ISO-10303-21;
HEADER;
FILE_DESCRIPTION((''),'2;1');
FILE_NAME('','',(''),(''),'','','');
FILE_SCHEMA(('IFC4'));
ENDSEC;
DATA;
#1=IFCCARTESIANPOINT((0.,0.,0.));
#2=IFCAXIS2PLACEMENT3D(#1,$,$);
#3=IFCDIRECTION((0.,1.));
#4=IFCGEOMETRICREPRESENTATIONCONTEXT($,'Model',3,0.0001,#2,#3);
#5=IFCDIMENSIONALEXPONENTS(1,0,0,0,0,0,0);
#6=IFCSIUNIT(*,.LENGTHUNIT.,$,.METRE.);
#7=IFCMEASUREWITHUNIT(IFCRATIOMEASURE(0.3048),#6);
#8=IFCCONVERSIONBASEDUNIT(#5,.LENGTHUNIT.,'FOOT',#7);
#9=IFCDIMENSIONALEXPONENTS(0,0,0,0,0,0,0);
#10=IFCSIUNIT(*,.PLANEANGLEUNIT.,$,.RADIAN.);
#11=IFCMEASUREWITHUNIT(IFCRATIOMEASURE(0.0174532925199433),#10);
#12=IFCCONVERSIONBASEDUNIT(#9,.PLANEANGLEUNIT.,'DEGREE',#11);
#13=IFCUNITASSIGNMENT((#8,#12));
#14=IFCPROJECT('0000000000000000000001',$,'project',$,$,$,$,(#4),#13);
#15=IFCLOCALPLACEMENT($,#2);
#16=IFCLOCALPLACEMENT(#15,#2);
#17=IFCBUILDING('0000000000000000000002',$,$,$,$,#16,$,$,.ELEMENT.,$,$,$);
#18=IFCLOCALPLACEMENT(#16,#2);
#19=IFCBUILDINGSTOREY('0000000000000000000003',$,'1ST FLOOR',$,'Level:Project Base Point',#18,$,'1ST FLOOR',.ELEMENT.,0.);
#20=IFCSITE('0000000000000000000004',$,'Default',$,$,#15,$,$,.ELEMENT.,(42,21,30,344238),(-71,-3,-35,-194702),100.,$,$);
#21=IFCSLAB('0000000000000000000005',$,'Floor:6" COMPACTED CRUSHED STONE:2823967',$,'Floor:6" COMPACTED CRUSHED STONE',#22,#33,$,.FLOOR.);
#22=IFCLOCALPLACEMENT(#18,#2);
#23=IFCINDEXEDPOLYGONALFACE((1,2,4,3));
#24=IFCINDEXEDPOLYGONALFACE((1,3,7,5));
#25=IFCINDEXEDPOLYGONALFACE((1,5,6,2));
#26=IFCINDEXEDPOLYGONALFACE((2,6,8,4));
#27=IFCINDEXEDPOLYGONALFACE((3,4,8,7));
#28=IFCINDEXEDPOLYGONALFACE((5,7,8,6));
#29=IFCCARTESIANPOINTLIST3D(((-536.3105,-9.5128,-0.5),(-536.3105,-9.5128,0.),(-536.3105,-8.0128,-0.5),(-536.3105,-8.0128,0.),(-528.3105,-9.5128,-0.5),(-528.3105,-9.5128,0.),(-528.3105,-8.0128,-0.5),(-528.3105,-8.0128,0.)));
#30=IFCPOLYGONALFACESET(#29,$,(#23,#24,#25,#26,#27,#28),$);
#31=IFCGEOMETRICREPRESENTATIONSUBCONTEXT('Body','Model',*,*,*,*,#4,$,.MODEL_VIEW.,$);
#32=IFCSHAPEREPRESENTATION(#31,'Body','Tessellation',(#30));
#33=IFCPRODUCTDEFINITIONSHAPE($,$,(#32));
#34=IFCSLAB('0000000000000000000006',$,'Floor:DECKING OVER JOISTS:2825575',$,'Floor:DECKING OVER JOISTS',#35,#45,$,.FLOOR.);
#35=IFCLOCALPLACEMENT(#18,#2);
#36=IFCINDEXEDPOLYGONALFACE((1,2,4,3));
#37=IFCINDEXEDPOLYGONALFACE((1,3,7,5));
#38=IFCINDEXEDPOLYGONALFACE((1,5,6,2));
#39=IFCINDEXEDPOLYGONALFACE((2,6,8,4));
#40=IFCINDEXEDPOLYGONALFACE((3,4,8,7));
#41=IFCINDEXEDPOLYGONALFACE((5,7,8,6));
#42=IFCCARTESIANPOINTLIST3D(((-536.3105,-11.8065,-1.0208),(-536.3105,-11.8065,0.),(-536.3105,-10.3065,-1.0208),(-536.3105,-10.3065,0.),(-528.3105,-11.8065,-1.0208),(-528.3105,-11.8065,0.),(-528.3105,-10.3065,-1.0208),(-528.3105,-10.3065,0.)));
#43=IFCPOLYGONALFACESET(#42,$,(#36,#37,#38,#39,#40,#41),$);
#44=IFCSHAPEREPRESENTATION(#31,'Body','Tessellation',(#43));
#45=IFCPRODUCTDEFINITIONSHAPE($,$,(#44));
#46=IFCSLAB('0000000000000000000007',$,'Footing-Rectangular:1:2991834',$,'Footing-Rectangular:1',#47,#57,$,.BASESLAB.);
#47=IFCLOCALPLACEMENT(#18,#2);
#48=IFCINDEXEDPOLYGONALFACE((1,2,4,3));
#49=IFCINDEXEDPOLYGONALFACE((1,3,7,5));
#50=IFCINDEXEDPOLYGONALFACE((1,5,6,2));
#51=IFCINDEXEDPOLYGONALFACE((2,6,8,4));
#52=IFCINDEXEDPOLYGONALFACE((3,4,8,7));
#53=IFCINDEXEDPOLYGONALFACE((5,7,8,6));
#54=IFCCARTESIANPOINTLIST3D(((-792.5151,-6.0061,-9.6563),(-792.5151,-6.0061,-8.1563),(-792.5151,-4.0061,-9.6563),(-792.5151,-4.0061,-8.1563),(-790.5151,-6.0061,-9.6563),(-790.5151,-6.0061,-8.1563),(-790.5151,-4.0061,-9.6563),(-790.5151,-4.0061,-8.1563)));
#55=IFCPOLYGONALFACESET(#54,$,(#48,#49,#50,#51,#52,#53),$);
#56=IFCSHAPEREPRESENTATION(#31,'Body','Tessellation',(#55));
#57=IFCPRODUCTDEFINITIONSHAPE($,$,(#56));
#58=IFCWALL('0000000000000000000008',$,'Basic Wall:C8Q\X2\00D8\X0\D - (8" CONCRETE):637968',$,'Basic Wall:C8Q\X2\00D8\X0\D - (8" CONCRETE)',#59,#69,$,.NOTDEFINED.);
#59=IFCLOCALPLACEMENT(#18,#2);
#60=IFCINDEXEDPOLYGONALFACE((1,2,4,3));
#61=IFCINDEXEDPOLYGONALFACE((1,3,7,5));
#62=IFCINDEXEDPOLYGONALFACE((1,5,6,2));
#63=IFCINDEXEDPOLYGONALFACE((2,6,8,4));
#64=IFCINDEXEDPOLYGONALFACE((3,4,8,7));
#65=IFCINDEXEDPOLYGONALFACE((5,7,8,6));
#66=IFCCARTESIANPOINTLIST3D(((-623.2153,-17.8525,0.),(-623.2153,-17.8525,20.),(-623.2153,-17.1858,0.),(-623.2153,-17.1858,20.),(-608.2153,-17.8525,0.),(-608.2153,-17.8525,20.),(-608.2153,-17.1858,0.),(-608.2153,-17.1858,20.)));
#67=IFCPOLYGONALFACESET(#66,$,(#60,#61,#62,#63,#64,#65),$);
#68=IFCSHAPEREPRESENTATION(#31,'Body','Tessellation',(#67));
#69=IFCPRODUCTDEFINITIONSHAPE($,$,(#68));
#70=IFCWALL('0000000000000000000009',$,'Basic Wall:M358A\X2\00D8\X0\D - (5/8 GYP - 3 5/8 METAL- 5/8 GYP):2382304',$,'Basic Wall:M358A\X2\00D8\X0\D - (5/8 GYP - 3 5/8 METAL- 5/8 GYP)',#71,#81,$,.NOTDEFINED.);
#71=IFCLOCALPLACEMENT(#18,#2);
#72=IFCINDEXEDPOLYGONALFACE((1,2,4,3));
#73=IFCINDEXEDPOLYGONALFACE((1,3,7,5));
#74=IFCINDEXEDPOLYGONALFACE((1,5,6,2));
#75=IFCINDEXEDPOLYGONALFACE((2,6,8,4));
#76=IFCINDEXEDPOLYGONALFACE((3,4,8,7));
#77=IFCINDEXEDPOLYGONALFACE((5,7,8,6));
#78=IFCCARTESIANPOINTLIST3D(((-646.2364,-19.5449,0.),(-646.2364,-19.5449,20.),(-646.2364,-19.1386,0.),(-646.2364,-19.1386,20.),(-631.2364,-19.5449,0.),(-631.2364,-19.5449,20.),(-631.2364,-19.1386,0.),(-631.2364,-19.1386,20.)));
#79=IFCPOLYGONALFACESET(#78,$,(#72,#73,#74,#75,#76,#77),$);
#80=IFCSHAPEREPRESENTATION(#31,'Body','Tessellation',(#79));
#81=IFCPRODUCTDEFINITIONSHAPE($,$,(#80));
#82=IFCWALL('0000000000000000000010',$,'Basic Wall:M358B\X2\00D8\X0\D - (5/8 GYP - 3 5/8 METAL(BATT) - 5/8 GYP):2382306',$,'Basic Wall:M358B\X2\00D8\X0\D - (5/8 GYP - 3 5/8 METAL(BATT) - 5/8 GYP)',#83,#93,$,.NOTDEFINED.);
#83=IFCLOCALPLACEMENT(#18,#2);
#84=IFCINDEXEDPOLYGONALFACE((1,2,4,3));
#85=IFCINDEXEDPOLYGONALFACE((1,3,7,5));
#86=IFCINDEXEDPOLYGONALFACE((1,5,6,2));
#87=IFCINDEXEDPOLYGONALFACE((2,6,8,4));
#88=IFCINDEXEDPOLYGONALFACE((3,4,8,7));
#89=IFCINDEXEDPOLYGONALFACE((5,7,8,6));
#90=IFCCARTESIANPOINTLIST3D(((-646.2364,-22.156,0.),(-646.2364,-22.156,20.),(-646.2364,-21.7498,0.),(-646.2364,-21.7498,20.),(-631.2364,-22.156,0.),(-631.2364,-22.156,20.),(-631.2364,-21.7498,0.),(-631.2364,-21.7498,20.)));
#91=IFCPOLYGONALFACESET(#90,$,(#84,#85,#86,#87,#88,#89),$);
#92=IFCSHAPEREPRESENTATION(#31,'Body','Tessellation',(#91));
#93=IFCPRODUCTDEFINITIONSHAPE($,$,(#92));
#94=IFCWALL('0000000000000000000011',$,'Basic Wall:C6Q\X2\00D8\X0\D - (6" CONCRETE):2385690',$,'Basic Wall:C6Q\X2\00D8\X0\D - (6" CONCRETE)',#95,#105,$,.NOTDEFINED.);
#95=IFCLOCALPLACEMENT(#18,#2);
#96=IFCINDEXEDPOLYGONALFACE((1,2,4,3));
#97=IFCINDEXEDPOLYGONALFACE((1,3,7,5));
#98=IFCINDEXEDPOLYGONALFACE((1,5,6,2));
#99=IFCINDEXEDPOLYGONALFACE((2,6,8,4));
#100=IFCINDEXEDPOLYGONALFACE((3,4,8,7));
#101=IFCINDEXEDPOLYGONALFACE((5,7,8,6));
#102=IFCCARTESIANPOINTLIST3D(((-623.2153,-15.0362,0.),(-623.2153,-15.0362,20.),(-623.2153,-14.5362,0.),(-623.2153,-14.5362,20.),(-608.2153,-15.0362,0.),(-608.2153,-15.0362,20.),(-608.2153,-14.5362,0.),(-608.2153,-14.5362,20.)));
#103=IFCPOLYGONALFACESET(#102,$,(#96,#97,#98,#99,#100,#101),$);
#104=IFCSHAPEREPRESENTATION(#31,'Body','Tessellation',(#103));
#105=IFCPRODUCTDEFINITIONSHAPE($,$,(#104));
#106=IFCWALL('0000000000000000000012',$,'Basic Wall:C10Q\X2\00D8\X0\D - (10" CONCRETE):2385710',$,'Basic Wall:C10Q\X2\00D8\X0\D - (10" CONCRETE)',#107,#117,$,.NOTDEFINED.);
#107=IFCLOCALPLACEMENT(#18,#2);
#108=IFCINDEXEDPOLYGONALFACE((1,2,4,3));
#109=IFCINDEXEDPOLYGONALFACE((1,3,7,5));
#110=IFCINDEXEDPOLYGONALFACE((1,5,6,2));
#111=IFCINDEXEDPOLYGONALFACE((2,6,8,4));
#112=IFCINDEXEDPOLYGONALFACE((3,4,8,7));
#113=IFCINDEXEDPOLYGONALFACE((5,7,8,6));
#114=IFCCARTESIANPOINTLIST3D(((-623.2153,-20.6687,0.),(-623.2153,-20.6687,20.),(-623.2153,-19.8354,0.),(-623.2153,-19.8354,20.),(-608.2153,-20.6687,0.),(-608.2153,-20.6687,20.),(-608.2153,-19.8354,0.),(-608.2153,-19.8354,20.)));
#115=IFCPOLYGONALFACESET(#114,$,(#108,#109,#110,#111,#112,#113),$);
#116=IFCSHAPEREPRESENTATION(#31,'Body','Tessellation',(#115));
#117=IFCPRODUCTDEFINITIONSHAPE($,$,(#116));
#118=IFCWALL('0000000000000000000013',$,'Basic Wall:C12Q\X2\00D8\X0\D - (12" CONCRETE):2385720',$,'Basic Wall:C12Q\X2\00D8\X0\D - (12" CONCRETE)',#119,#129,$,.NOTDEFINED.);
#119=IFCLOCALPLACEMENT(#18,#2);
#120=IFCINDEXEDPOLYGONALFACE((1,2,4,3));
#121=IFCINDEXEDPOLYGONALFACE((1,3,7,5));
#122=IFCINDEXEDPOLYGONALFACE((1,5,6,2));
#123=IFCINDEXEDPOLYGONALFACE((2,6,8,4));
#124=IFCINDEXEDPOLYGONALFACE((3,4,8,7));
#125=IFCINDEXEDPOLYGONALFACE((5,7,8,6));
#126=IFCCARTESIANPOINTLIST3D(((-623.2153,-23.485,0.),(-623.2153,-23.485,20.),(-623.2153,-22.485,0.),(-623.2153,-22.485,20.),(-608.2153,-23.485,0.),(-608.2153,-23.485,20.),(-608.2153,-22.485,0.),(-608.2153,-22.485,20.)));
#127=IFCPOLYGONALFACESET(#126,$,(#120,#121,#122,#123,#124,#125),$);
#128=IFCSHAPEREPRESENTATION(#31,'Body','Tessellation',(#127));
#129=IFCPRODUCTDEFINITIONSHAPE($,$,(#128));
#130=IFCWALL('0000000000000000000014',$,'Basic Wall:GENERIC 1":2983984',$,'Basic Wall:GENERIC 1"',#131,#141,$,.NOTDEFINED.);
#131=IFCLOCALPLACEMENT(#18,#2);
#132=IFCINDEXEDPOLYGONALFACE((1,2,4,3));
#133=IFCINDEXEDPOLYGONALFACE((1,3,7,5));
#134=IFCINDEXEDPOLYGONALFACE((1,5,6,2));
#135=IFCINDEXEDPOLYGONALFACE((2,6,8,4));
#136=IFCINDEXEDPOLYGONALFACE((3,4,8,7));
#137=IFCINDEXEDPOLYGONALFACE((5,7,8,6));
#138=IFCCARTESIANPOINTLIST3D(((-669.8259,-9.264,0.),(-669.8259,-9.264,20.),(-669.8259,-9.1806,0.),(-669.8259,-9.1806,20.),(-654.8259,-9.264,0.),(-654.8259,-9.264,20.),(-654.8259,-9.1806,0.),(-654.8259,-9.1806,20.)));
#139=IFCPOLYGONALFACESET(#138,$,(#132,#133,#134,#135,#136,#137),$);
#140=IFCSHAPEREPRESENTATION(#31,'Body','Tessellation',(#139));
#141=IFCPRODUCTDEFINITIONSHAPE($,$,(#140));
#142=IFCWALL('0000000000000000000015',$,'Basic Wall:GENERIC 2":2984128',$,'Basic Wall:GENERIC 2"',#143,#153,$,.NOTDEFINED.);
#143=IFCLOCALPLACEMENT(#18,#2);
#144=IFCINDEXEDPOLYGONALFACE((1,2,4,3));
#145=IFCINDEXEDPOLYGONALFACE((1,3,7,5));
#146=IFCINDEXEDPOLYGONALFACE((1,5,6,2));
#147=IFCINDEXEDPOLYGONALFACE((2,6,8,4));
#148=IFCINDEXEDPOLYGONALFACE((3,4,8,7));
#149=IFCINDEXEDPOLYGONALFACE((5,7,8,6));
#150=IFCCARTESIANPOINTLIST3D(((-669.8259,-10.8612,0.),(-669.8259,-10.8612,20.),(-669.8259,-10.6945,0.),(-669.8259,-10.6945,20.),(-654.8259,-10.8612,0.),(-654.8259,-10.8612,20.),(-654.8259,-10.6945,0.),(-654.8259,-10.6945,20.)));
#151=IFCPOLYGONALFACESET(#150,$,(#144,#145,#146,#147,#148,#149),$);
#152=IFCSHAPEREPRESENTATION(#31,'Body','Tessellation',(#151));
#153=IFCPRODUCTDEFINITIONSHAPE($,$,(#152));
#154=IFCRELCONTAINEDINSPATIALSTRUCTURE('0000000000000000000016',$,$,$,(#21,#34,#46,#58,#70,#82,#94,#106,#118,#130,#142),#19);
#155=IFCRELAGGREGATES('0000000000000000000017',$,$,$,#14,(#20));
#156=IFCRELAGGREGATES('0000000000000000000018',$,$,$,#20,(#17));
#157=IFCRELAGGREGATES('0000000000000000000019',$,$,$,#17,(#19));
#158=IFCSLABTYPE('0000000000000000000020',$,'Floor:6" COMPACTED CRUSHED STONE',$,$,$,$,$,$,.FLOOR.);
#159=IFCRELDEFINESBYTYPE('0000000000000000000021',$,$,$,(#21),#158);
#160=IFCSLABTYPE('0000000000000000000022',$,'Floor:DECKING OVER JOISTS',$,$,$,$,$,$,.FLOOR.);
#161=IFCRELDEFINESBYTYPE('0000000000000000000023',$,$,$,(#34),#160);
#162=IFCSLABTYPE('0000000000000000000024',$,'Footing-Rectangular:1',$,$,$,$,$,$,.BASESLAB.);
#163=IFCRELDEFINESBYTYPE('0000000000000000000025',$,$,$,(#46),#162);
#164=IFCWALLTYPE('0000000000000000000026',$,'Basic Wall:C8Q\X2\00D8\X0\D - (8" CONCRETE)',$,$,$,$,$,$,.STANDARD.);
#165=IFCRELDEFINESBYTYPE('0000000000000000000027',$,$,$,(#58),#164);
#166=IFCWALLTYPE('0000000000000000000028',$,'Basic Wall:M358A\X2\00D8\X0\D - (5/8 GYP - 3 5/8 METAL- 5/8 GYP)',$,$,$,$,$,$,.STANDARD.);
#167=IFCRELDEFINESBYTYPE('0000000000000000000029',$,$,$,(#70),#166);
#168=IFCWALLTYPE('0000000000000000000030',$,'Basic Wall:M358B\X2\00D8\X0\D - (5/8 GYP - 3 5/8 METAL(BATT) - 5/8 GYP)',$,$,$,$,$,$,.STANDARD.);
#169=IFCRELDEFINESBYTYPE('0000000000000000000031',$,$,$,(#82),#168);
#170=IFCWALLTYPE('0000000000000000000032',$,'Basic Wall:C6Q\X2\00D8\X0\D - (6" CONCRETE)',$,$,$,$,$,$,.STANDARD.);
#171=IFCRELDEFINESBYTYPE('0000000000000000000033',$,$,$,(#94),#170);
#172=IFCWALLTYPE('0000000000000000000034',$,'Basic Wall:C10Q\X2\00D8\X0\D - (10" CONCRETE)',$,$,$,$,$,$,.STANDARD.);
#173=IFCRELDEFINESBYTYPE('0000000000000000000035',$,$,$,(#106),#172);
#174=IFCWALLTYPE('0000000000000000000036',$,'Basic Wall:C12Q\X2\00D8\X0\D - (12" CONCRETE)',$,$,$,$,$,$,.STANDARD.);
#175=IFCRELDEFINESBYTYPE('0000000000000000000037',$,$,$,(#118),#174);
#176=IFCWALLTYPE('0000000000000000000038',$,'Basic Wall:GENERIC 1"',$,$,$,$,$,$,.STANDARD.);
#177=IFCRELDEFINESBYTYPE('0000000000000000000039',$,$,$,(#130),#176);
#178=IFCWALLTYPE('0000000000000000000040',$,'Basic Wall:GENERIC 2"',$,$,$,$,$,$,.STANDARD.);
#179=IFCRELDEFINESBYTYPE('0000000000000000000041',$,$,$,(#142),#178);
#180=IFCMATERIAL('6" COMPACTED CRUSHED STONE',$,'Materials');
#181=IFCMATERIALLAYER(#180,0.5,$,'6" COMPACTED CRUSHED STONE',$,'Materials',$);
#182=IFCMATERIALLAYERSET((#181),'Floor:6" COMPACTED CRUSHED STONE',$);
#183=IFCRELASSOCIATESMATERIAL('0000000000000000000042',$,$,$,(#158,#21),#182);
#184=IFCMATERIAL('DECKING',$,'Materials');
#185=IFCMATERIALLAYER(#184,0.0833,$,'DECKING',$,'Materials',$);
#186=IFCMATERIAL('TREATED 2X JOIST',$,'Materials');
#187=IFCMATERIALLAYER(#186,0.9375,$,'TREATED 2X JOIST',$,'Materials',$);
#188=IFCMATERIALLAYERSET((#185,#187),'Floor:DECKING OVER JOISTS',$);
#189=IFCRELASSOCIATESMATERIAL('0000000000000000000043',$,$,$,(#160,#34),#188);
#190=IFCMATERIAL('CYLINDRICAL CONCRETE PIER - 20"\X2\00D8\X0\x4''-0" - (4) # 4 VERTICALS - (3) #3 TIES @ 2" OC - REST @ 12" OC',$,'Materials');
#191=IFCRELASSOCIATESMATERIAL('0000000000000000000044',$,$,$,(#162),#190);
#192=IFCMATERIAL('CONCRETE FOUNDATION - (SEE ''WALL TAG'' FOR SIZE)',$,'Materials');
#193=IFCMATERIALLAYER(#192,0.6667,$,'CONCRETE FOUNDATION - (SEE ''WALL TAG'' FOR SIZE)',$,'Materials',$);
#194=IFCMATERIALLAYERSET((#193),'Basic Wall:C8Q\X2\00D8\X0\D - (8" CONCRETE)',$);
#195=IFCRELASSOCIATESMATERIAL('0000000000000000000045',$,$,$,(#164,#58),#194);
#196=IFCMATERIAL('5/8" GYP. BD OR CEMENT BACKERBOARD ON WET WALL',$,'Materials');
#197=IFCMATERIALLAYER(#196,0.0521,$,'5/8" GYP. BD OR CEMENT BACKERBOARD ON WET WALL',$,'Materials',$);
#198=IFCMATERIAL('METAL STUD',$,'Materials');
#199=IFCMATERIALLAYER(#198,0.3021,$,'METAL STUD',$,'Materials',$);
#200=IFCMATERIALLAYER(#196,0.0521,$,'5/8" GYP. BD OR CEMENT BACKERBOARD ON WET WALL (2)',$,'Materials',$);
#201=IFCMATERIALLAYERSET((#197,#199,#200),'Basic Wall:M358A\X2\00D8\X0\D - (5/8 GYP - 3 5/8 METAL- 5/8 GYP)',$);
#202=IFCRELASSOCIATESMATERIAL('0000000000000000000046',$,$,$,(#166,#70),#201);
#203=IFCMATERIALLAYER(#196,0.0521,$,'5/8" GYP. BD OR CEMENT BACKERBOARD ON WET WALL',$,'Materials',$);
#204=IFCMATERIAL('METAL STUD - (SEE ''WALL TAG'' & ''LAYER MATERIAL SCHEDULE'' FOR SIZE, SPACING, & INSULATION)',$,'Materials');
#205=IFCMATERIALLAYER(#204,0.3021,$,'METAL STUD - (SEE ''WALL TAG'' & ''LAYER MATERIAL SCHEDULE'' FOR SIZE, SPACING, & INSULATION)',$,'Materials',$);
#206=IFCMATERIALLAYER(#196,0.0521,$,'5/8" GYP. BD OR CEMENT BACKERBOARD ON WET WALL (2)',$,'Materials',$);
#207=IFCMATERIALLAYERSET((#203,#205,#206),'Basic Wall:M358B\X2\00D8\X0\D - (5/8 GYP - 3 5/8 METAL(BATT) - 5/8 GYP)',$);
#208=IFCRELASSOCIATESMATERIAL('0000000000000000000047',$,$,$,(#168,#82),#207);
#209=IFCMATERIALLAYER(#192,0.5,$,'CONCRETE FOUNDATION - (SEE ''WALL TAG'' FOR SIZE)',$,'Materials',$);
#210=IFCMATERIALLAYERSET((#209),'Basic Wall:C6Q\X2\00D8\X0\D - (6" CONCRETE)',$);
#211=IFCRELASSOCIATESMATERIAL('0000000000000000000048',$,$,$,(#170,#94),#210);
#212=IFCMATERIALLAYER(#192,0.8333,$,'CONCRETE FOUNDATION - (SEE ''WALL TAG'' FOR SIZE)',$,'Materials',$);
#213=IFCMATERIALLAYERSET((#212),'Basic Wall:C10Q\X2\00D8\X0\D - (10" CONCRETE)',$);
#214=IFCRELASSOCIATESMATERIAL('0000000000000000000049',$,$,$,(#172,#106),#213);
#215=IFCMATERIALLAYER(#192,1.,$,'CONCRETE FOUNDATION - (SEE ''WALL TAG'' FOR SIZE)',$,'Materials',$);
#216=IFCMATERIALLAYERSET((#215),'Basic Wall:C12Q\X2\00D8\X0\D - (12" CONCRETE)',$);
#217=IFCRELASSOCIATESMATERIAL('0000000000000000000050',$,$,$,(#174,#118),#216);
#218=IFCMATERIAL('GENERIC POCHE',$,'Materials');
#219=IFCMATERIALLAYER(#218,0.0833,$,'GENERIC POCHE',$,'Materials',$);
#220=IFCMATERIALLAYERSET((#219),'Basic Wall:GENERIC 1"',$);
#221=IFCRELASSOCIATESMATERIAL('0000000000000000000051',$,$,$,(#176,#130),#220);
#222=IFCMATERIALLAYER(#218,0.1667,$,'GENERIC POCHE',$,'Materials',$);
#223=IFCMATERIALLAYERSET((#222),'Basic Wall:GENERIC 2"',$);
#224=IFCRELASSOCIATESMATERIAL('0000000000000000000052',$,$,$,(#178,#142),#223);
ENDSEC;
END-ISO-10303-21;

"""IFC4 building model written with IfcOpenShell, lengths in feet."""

from ifc_helpers import new_model, entity, si_unit, converted_unit, direction, frame, frame_2d, origin, origin_2d_with_axis, place, context, subcontext, project, spatial, rectangle, extrude, material, layer, layer_set, layer_usage, type_object, element, save


model = new_model("IFC4")

# Units and contexts
model_context = context("Model", 3, precision=0.0001, world=origin(), true_north=direction((0.0, 1.0)))
body_context = subcontext(model_context, "Body", "Model", "MODEL_VIEW")
ifc_project = project(units=[converted_unit("LENGTHUNIT", "FOOT", entity("IfcRatioMeasure", 0.3048), si_unit("LENGTHUNIT", "METRE"), dimensions=[1, 0, 0, 0, 0, 0, 0]), converted_unit("PLANEANGLEUNIT", "DEGREE", entity("IfcRatioMeasure", 0.0174532925199433), si_unit("PLANEANGLEUNIT", "RADIAN"), dimensions=[0, 0, 0, 0, 0, 0, 0])], contexts=[model_context])

# Site, building, storey
site_placement = place(None, origin())
site = spatial("IfcSite", under=ifc_project, at=site_placement, Name="Default", CompositionType="ELEMENT", RefLatitude=(42, 21, 30, 344238), RefLongitude=(-71, -3, -35, -194702), RefElevation=100.0)
building_placement = place(site_placement, origin())
building = spatial("IfcBuilding", under=site, at=building_placement, CompositionType="ELEMENT")
storey_placement = place(building_placement, origin())
storey = spatial("IfcBuildingStorey", under=building, at=storey_placement, Name="1ST FLOOR", ObjectType="Level:Project Base Point", LongName="1ST FLOOR", CompositionType="ELEMENT", Elevation=0.0)

# Slabs
ifc_material_1 = material(Name="6\" COMPACTED CRUSHED STONE", Category="Materials")
ifc_layer_1 = layer(ifc_material_1, 0.5, Name="6\" COMPACTED CRUSHED STONE", Category="Materials")
ifc_layer_set_1 = layer_set([ifc_layer_1], Name="Floor:6\" COMPACTED CRUSHED STONE")
ifc_layer_usage_1 = layer_usage(ifc_layer_set_1, "AXIS3", "POSITIVE", 0.0)
slab_type_1 = type_object("IfcSlabType", Name="Floor:6\" COMPACTED CRUSHED STONE", PredefinedType="FLOOR", material=ifc_layer_set_1)
slab_1_placement = place(storey_placement, origin())
element("IfcSlab", 1, at=slab_1_placement, inside=storey, type_object=slab_type_1, material=ifc_layer_usage_1, Name="Floor:6\" COMPACTED CRUSHED STONE:2823967", ObjectType="Floor:6\" COMPACTED CRUSHED STONE", PredefinedType="FLOOR", context=body_context, shape_type="SweptSolid", body=[
    extrude(rectangle(XDim=1.5, YDim=8.0, at=origin_2d_with_axis()), frame((-532.3105, -8.7628, 0.0), z_axis=(0.0, 0.0, -1.0), x_axis=(0.0, 1.0, 0.0)), (0.0, 0.0, 1.0), 0.5),
])
ifc_material_2 = material(Name="DECKING", Category="Materials")
ifc_layer_2 = layer(ifc_material_2, 0.0833, Name="DECKING", Category="Materials")
ifc_material_3 = material(Name="TREATED 2X JOIST", Category="Materials")
ifc_layer_3 = layer(ifc_material_3, 0.9375, Name="TREATED 2X JOIST", Category="Materials")
ifc_layer_set_2 = layer_set([ifc_layer_2, ifc_layer_3], Name="Floor:DECKING OVER JOISTS")
ifc_layer_usage_2 = layer_usage(ifc_layer_set_2, "AXIS3", "POSITIVE", 0.0)
slab_type_2 = type_object("IfcSlabType", Name="Floor:DECKING OVER JOISTS", PredefinedType="FLOOR", material=ifc_layer_set_2)
slab_2_placement = place(storey_placement, origin())
element("IfcSlab", 2, at=slab_2_placement, inside=storey, type_object=slab_type_2, material=ifc_layer_usage_2, Name="Floor:DECKING OVER JOISTS:2825575", ObjectType="Floor:DECKING OVER JOISTS", PredefinedType="FLOOR", context=body_context, shape_type="SweptSolid", body=[
    extrude(rectangle(XDim=1.5, YDim=8.0, at=origin_2d_with_axis()), frame((-532.3105, -11.0565, 0.0), z_axis=(0.0, 0.0, -1.0), x_axis=(0.0, 1.0, 0.0)), (0.0, 0.0, 1.0), 1.0208),
])
ifc_material_4 = material(Name="CYLINDRICAL CONCRETE PIER - 20\"Øx4'-0\" - (4) # 4 VERTICALS - (3) #3 TIES @ 2\" OC - REST @ 12\" OC", Category="Materials")
slab_type_3 = type_object("IfcSlabType", Name="Footing-Rectangular:1", PredefinedType="BASESLAB", material=ifc_material_4)
slab_3_placement = place(storey_placement, frame((-792.5151, -6.0061, -9.6563)))
element("IfcSlab", 3, at=slab_3_placement, inside=storey, type_object=slab_type_3, Name="Footing-Rectangular:1:2991834", ObjectType="Footing-Rectangular:1", PredefinedType="BASESLAB", context=body_context, shape_type="SweptSolid", body=[
    extrude(rectangle(XDim=2.0, YDim=2.0, at=origin_2d_with_axis()), frame((1.0, 1.0, 0.0), z_axis=(0.0, 0.0, 1.0), x_axis=(-1.0, 0.0, 0.0)), (0.0, 0.0, 1.0), 1.5),
])

# Walls
ifc_material_5 = material(Name="CONCRETE FOUNDATION - (SEE 'WALL TAG' FOR SIZE)", Category="Materials")
ifc_layer_4 = layer(ifc_material_5, 0.6667, Name="CONCRETE FOUNDATION - (SEE 'WALL TAG' FOR SIZE)", Category="Materials")
ifc_layer_set_3 = layer_set([ifc_layer_4], Name="Basic Wall:C8QØD - (8\" CONCRETE)")
ifc_layer_usage_3 = layer_usage(ifc_layer_set_3, "AXIS2", "NEGATIVE", 0.3333)
wall_type_1 = type_object("IfcWallType", Name="Basic Wall:C8QØD - (8\" CONCRETE)", PredefinedType="STANDARD", material=ifc_layer_set_3)
wall_1_placement = place(storey_placement, frame((-623.2153, -17.5191, 0.0)))
element("IfcWall", 4, at=wall_1_placement, inside=storey, type_object=wall_type_1, material=ifc_layer_usage_3, Name="Basic Wall:C8QØD - (8\" CONCRETE):637968", ObjectType="Basic Wall:C8QØD - (8\" CONCRETE)", PredefinedType="NOTDEFINED", context=body_context, shape_type="SweptSolid", body=[
    extrude(rectangle(XDim=15.0, YDim=0.6667, at=frame_2d((7.5, 0.0), x_axis=(-1.0, 0.0))), origin(), (0.0, 0.0, 1.0), 20.0),
])
ifc_material_6 = material(Name="5/8\" GYP. BD OR CEMENT BACKERBOARD ON WET WALL", Category="Materials")
ifc_layer_5 = layer(ifc_material_6, 0.0521, Name="5/8\" GYP. BD OR CEMENT BACKERBOARD ON WET WALL", Category="Materials")
ifc_material_7 = material(Name="METAL STUD", Category="Materials")
ifc_layer_6 = layer(ifc_material_7, 0.3021, Name="METAL STUD", Category="Materials")
ifc_layer_7 = layer(ifc_material_6, 0.0521, Name="5/8\" GYP. BD OR CEMENT BACKERBOARD ON WET WALL (2)", Category="Materials")
ifc_layer_set_4 = layer_set([ifc_layer_5, ifc_layer_6, ifc_layer_7], Name="Basic Wall:M358AØD - (5/8 GYP - 3 5/8 METAL- 5/8 GYP)")
ifc_layer_usage_4 = layer_usage(ifc_layer_set_4, "AXIS2", "NEGATIVE", 0.2031)
wall_type_2 = type_object("IfcWallType", Name="Basic Wall:M358AØD - (5/8 GYP - 3 5/8 METAL- 5/8 GYP)", PredefinedType="STANDARD", material=ifc_layer_set_4)
wall_2_placement = place(storey_placement, frame((-646.2364, -19.3418, 0.0)))
element("IfcWall", 5, at=wall_2_placement, inside=storey, type_object=wall_type_2, material=ifc_layer_usage_4, Name="Basic Wall:M358AØD - (5/8 GYP - 3 5/8 METAL- 5/8 GYP):2382304", ObjectType="Basic Wall:M358AØD - (5/8 GYP - 3 5/8 METAL- 5/8 GYP)", PredefinedType="NOTDEFINED", context=body_context, shape_type="SweptSolid", body=[
    extrude(rectangle(XDim=15.0, YDim=0.4062, at=frame_2d((7.5, 0.0), x_axis=(-1.0, 0.0))), origin(), (0.0, 0.0, 1.0), 20.0),
])
ifc_layer_8 = layer(ifc_material_6, 0.0521, Name="5/8\" GYP. BD OR CEMENT BACKERBOARD ON WET WALL", Category="Materials")
ifc_material_8 = material(Name="METAL STUD - (SEE 'WALL TAG' & 'LAYER MATERIAL SCHEDULE' FOR SIZE, SPACING, & INSULATION)", Category="Materials")
ifc_layer_9 = layer(ifc_material_8, 0.3021, Name="METAL STUD - (SEE 'WALL TAG' & 'LAYER MATERIAL SCHEDULE' FOR SIZE, SPACING, & INSULATION)", Category="Materials")
ifc_layer_10 = layer(ifc_material_6, 0.0521, Name="5/8\" GYP. BD OR CEMENT BACKERBOARD ON WET WALL (2)", Category="Materials")
ifc_layer_set_5 = layer_set([ifc_layer_8, ifc_layer_9, ifc_layer_10], Name="Basic Wall:M358BØD - (5/8 GYP - 3 5/8 METAL(BATT) - 5/8 GYP)")
ifc_layer_usage_5 = layer_usage(ifc_layer_set_5, "AXIS2", "NEGATIVE", 0.2031)
wall_type_3 = type_object("IfcWallType", Name="Basic Wall:M358BØD - (5/8 GYP - 3 5/8 METAL(BATT) - 5/8 GYP)", PredefinedType="STANDARD", material=ifc_layer_set_5)
wall_3_placement = place(storey_placement, frame((-646.2364, -21.9529, 0.0)))
element("IfcWall", 6, at=wall_3_placement, inside=storey, type_object=wall_type_3, material=ifc_layer_usage_5, Name="Basic Wall:M358BØD - (5/8 GYP - 3 5/8 METAL(BATT) - 5/8 GYP):2382306", ObjectType="Basic Wall:M358BØD - (5/8 GYP - 3 5/8 METAL(BATT) - 5/8 GYP)", PredefinedType="NOTDEFINED", context=body_context, shape_type="SweptSolid", body=[
    extrude(rectangle(XDim=15.0, YDim=0.4062, at=frame_2d((7.5, 0.0), x_axis=(-1.0, 0.0))), origin(), (0.0, 0.0, 1.0), 20.0),
])
ifc_layer_11 = layer(ifc_material_5, 0.5, Name="CONCRETE FOUNDATION - (SEE 'WALL TAG' FOR SIZE)", Category="Materials")
ifc_layer_set_6 = layer_set([ifc_layer_11], Name="Basic Wall:C6QØD - (6\" CONCRETE)")
ifc_layer_usage_6 = layer_usage(ifc_layer_set_6, "AXIS2", "NEGATIVE", 0.25)
wall_type_4 = type_object("IfcWallType", Name="Basic Wall:C6QØD - (6\" CONCRETE)", PredefinedType="STANDARD", material=ifc_layer_set_6)
wall_4_placement = place(storey_placement, frame((-623.2153, -14.7862, 0.0)))
element("IfcWall", 7, at=wall_4_placement, inside=storey, type_object=wall_type_4, material=ifc_layer_usage_6, Name="Basic Wall:C6QØD - (6\" CONCRETE):2385690", ObjectType="Basic Wall:C6QØD - (6\" CONCRETE)", PredefinedType="NOTDEFINED", context=body_context, shape_type="SweptSolid", body=[
    extrude(rectangle(XDim=15.0, YDim=0.5, at=frame_2d((7.5, 0.0), x_axis=(-1.0, 0.0))), origin(), (0.0, 0.0, 1.0), 20.0),
])
ifc_layer_12 = layer(ifc_material_5, 0.8333, Name="CONCRETE FOUNDATION - (SEE 'WALL TAG' FOR SIZE)", Category="Materials")
ifc_layer_set_7 = layer_set([ifc_layer_12], Name="Basic Wall:C10QØD - (10\" CONCRETE)")
ifc_layer_usage_7 = layer_usage(ifc_layer_set_7, "AXIS2", "NEGATIVE", 0.4167)
wall_type_5 = type_object("IfcWallType", Name="Basic Wall:C10QØD - (10\" CONCRETE)", PredefinedType="STANDARD", material=ifc_layer_set_7)
wall_5_placement = place(storey_placement, frame((-623.2153, -20.2521, 0.0)))
element("IfcWall", 8, at=wall_5_placement, inside=storey, type_object=wall_type_5, material=ifc_layer_usage_7, Name="Basic Wall:C10QØD - (10\" CONCRETE):2385710", ObjectType="Basic Wall:C10QØD - (10\" CONCRETE)", PredefinedType="NOTDEFINED", context=body_context, shape_type="SweptSolid", body=[
    extrude(rectangle(XDim=15.0, YDim=0.8333, at=frame_2d((7.5, 0.0), x_axis=(-1.0, 0.0))), origin(), (0.0, 0.0, 1.0), 20.0),
])
ifc_layer_13 = layer(ifc_material_5, 1.0, Name="CONCRETE FOUNDATION - (SEE 'WALL TAG' FOR SIZE)", Category="Materials")
ifc_layer_set_8 = layer_set([ifc_layer_13], Name="Basic Wall:C12QØD - (12\" CONCRETE)")
ifc_layer_usage_8 = layer_usage(ifc_layer_set_8, "AXIS2", "NEGATIVE", 0.5)
wall_type_6 = type_object("IfcWallType", Name="Basic Wall:C12QØD - (12\" CONCRETE)", PredefinedType="STANDARD", material=ifc_layer_set_8)
wall_6_placement = place(storey_placement, frame((-623.2153, -22.985, 0.0)))
element("IfcWall", 9, at=wall_6_placement, inside=storey, type_object=wall_type_6, material=ifc_layer_usage_8, Name="Basic Wall:C12QØD - (12\" CONCRETE):2385720", ObjectType="Basic Wall:C12QØD - (12\" CONCRETE)", PredefinedType="NOTDEFINED", context=body_context, shape_type="SweptSolid", body=[
    extrude(rectangle(XDim=15.0, YDim=1.0, at=frame_2d((7.5, 0.0), x_axis=(-1.0, 0.0))), origin(), (0.0, 0.0, 1.0), 20.0),
])
ifc_material_9 = material(Name="GENERIC POCHE", Category="Materials")
ifc_layer_14 = layer(ifc_material_9, 0.0833, Name="GENERIC POCHE", Category="Materials")
ifc_layer_set_9 = layer_set([ifc_layer_14], Name="Basic Wall:GENERIC 1\"")
ifc_layer_usage_9 = layer_usage(ifc_layer_set_9, "AXIS2", "NEGATIVE", 0.0417)
wall_type_7 = type_object("IfcWallType", Name="Basic Wall:GENERIC 1\"", PredefinedType="STANDARD", material=ifc_layer_set_9)
wall_7_placement = place(storey_placement, frame((-669.8259, -9.2223, 0.0)))
element("IfcWall", 10, at=wall_7_placement, inside=storey, type_object=wall_type_7, material=ifc_layer_usage_9, Name="Basic Wall:GENERIC 1\":2983984", ObjectType="Basic Wall:GENERIC 1\"", PredefinedType="NOTDEFINED", context=body_context, shape_type="SweptSolid", body=[
    extrude(rectangle(XDim=15.0, YDim=0.0833, at=frame_2d((7.5, 0.0), x_axis=(-1.0, 0.0))), origin(), (0.0, 0.0, 1.0), 20.0),
])
ifc_layer_15 = layer(ifc_material_9, 0.1667, Name="GENERIC POCHE", Category="Materials")
ifc_layer_set_10 = layer_set([ifc_layer_15], Name="Basic Wall:GENERIC 2\"")
ifc_layer_usage_10 = layer_usage(ifc_layer_set_10, "AXIS2", "NEGATIVE", 0.0833)
wall_type_8 = type_object("IfcWallType", Name="Basic Wall:GENERIC 2\"", PredefinedType="STANDARD", material=ifc_layer_set_10)
wall_8_placement = place(storey_placement, frame((-669.8259, -10.7779, 0.0)))
element("IfcWall", 11, at=wall_8_placement, inside=storey, type_object=wall_type_8, material=ifc_layer_usage_10, Name="Basic Wall:GENERIC 2\":2984128", ObjectType="Basic Wall:GENERIC 2\"", PredefinedType="NOTDEFINED", context=body_context, shape_type="SweptSolid", body=[
    extrude(rectangle(XDim=15.0, YDim=0.1667, at=frame_2d((7.5, 0.0), x_axis=(-1.0, 0.0))), origin(), (0.0, 0.0, 1.0), 20.0),
])

save(model, "model.ifc")
